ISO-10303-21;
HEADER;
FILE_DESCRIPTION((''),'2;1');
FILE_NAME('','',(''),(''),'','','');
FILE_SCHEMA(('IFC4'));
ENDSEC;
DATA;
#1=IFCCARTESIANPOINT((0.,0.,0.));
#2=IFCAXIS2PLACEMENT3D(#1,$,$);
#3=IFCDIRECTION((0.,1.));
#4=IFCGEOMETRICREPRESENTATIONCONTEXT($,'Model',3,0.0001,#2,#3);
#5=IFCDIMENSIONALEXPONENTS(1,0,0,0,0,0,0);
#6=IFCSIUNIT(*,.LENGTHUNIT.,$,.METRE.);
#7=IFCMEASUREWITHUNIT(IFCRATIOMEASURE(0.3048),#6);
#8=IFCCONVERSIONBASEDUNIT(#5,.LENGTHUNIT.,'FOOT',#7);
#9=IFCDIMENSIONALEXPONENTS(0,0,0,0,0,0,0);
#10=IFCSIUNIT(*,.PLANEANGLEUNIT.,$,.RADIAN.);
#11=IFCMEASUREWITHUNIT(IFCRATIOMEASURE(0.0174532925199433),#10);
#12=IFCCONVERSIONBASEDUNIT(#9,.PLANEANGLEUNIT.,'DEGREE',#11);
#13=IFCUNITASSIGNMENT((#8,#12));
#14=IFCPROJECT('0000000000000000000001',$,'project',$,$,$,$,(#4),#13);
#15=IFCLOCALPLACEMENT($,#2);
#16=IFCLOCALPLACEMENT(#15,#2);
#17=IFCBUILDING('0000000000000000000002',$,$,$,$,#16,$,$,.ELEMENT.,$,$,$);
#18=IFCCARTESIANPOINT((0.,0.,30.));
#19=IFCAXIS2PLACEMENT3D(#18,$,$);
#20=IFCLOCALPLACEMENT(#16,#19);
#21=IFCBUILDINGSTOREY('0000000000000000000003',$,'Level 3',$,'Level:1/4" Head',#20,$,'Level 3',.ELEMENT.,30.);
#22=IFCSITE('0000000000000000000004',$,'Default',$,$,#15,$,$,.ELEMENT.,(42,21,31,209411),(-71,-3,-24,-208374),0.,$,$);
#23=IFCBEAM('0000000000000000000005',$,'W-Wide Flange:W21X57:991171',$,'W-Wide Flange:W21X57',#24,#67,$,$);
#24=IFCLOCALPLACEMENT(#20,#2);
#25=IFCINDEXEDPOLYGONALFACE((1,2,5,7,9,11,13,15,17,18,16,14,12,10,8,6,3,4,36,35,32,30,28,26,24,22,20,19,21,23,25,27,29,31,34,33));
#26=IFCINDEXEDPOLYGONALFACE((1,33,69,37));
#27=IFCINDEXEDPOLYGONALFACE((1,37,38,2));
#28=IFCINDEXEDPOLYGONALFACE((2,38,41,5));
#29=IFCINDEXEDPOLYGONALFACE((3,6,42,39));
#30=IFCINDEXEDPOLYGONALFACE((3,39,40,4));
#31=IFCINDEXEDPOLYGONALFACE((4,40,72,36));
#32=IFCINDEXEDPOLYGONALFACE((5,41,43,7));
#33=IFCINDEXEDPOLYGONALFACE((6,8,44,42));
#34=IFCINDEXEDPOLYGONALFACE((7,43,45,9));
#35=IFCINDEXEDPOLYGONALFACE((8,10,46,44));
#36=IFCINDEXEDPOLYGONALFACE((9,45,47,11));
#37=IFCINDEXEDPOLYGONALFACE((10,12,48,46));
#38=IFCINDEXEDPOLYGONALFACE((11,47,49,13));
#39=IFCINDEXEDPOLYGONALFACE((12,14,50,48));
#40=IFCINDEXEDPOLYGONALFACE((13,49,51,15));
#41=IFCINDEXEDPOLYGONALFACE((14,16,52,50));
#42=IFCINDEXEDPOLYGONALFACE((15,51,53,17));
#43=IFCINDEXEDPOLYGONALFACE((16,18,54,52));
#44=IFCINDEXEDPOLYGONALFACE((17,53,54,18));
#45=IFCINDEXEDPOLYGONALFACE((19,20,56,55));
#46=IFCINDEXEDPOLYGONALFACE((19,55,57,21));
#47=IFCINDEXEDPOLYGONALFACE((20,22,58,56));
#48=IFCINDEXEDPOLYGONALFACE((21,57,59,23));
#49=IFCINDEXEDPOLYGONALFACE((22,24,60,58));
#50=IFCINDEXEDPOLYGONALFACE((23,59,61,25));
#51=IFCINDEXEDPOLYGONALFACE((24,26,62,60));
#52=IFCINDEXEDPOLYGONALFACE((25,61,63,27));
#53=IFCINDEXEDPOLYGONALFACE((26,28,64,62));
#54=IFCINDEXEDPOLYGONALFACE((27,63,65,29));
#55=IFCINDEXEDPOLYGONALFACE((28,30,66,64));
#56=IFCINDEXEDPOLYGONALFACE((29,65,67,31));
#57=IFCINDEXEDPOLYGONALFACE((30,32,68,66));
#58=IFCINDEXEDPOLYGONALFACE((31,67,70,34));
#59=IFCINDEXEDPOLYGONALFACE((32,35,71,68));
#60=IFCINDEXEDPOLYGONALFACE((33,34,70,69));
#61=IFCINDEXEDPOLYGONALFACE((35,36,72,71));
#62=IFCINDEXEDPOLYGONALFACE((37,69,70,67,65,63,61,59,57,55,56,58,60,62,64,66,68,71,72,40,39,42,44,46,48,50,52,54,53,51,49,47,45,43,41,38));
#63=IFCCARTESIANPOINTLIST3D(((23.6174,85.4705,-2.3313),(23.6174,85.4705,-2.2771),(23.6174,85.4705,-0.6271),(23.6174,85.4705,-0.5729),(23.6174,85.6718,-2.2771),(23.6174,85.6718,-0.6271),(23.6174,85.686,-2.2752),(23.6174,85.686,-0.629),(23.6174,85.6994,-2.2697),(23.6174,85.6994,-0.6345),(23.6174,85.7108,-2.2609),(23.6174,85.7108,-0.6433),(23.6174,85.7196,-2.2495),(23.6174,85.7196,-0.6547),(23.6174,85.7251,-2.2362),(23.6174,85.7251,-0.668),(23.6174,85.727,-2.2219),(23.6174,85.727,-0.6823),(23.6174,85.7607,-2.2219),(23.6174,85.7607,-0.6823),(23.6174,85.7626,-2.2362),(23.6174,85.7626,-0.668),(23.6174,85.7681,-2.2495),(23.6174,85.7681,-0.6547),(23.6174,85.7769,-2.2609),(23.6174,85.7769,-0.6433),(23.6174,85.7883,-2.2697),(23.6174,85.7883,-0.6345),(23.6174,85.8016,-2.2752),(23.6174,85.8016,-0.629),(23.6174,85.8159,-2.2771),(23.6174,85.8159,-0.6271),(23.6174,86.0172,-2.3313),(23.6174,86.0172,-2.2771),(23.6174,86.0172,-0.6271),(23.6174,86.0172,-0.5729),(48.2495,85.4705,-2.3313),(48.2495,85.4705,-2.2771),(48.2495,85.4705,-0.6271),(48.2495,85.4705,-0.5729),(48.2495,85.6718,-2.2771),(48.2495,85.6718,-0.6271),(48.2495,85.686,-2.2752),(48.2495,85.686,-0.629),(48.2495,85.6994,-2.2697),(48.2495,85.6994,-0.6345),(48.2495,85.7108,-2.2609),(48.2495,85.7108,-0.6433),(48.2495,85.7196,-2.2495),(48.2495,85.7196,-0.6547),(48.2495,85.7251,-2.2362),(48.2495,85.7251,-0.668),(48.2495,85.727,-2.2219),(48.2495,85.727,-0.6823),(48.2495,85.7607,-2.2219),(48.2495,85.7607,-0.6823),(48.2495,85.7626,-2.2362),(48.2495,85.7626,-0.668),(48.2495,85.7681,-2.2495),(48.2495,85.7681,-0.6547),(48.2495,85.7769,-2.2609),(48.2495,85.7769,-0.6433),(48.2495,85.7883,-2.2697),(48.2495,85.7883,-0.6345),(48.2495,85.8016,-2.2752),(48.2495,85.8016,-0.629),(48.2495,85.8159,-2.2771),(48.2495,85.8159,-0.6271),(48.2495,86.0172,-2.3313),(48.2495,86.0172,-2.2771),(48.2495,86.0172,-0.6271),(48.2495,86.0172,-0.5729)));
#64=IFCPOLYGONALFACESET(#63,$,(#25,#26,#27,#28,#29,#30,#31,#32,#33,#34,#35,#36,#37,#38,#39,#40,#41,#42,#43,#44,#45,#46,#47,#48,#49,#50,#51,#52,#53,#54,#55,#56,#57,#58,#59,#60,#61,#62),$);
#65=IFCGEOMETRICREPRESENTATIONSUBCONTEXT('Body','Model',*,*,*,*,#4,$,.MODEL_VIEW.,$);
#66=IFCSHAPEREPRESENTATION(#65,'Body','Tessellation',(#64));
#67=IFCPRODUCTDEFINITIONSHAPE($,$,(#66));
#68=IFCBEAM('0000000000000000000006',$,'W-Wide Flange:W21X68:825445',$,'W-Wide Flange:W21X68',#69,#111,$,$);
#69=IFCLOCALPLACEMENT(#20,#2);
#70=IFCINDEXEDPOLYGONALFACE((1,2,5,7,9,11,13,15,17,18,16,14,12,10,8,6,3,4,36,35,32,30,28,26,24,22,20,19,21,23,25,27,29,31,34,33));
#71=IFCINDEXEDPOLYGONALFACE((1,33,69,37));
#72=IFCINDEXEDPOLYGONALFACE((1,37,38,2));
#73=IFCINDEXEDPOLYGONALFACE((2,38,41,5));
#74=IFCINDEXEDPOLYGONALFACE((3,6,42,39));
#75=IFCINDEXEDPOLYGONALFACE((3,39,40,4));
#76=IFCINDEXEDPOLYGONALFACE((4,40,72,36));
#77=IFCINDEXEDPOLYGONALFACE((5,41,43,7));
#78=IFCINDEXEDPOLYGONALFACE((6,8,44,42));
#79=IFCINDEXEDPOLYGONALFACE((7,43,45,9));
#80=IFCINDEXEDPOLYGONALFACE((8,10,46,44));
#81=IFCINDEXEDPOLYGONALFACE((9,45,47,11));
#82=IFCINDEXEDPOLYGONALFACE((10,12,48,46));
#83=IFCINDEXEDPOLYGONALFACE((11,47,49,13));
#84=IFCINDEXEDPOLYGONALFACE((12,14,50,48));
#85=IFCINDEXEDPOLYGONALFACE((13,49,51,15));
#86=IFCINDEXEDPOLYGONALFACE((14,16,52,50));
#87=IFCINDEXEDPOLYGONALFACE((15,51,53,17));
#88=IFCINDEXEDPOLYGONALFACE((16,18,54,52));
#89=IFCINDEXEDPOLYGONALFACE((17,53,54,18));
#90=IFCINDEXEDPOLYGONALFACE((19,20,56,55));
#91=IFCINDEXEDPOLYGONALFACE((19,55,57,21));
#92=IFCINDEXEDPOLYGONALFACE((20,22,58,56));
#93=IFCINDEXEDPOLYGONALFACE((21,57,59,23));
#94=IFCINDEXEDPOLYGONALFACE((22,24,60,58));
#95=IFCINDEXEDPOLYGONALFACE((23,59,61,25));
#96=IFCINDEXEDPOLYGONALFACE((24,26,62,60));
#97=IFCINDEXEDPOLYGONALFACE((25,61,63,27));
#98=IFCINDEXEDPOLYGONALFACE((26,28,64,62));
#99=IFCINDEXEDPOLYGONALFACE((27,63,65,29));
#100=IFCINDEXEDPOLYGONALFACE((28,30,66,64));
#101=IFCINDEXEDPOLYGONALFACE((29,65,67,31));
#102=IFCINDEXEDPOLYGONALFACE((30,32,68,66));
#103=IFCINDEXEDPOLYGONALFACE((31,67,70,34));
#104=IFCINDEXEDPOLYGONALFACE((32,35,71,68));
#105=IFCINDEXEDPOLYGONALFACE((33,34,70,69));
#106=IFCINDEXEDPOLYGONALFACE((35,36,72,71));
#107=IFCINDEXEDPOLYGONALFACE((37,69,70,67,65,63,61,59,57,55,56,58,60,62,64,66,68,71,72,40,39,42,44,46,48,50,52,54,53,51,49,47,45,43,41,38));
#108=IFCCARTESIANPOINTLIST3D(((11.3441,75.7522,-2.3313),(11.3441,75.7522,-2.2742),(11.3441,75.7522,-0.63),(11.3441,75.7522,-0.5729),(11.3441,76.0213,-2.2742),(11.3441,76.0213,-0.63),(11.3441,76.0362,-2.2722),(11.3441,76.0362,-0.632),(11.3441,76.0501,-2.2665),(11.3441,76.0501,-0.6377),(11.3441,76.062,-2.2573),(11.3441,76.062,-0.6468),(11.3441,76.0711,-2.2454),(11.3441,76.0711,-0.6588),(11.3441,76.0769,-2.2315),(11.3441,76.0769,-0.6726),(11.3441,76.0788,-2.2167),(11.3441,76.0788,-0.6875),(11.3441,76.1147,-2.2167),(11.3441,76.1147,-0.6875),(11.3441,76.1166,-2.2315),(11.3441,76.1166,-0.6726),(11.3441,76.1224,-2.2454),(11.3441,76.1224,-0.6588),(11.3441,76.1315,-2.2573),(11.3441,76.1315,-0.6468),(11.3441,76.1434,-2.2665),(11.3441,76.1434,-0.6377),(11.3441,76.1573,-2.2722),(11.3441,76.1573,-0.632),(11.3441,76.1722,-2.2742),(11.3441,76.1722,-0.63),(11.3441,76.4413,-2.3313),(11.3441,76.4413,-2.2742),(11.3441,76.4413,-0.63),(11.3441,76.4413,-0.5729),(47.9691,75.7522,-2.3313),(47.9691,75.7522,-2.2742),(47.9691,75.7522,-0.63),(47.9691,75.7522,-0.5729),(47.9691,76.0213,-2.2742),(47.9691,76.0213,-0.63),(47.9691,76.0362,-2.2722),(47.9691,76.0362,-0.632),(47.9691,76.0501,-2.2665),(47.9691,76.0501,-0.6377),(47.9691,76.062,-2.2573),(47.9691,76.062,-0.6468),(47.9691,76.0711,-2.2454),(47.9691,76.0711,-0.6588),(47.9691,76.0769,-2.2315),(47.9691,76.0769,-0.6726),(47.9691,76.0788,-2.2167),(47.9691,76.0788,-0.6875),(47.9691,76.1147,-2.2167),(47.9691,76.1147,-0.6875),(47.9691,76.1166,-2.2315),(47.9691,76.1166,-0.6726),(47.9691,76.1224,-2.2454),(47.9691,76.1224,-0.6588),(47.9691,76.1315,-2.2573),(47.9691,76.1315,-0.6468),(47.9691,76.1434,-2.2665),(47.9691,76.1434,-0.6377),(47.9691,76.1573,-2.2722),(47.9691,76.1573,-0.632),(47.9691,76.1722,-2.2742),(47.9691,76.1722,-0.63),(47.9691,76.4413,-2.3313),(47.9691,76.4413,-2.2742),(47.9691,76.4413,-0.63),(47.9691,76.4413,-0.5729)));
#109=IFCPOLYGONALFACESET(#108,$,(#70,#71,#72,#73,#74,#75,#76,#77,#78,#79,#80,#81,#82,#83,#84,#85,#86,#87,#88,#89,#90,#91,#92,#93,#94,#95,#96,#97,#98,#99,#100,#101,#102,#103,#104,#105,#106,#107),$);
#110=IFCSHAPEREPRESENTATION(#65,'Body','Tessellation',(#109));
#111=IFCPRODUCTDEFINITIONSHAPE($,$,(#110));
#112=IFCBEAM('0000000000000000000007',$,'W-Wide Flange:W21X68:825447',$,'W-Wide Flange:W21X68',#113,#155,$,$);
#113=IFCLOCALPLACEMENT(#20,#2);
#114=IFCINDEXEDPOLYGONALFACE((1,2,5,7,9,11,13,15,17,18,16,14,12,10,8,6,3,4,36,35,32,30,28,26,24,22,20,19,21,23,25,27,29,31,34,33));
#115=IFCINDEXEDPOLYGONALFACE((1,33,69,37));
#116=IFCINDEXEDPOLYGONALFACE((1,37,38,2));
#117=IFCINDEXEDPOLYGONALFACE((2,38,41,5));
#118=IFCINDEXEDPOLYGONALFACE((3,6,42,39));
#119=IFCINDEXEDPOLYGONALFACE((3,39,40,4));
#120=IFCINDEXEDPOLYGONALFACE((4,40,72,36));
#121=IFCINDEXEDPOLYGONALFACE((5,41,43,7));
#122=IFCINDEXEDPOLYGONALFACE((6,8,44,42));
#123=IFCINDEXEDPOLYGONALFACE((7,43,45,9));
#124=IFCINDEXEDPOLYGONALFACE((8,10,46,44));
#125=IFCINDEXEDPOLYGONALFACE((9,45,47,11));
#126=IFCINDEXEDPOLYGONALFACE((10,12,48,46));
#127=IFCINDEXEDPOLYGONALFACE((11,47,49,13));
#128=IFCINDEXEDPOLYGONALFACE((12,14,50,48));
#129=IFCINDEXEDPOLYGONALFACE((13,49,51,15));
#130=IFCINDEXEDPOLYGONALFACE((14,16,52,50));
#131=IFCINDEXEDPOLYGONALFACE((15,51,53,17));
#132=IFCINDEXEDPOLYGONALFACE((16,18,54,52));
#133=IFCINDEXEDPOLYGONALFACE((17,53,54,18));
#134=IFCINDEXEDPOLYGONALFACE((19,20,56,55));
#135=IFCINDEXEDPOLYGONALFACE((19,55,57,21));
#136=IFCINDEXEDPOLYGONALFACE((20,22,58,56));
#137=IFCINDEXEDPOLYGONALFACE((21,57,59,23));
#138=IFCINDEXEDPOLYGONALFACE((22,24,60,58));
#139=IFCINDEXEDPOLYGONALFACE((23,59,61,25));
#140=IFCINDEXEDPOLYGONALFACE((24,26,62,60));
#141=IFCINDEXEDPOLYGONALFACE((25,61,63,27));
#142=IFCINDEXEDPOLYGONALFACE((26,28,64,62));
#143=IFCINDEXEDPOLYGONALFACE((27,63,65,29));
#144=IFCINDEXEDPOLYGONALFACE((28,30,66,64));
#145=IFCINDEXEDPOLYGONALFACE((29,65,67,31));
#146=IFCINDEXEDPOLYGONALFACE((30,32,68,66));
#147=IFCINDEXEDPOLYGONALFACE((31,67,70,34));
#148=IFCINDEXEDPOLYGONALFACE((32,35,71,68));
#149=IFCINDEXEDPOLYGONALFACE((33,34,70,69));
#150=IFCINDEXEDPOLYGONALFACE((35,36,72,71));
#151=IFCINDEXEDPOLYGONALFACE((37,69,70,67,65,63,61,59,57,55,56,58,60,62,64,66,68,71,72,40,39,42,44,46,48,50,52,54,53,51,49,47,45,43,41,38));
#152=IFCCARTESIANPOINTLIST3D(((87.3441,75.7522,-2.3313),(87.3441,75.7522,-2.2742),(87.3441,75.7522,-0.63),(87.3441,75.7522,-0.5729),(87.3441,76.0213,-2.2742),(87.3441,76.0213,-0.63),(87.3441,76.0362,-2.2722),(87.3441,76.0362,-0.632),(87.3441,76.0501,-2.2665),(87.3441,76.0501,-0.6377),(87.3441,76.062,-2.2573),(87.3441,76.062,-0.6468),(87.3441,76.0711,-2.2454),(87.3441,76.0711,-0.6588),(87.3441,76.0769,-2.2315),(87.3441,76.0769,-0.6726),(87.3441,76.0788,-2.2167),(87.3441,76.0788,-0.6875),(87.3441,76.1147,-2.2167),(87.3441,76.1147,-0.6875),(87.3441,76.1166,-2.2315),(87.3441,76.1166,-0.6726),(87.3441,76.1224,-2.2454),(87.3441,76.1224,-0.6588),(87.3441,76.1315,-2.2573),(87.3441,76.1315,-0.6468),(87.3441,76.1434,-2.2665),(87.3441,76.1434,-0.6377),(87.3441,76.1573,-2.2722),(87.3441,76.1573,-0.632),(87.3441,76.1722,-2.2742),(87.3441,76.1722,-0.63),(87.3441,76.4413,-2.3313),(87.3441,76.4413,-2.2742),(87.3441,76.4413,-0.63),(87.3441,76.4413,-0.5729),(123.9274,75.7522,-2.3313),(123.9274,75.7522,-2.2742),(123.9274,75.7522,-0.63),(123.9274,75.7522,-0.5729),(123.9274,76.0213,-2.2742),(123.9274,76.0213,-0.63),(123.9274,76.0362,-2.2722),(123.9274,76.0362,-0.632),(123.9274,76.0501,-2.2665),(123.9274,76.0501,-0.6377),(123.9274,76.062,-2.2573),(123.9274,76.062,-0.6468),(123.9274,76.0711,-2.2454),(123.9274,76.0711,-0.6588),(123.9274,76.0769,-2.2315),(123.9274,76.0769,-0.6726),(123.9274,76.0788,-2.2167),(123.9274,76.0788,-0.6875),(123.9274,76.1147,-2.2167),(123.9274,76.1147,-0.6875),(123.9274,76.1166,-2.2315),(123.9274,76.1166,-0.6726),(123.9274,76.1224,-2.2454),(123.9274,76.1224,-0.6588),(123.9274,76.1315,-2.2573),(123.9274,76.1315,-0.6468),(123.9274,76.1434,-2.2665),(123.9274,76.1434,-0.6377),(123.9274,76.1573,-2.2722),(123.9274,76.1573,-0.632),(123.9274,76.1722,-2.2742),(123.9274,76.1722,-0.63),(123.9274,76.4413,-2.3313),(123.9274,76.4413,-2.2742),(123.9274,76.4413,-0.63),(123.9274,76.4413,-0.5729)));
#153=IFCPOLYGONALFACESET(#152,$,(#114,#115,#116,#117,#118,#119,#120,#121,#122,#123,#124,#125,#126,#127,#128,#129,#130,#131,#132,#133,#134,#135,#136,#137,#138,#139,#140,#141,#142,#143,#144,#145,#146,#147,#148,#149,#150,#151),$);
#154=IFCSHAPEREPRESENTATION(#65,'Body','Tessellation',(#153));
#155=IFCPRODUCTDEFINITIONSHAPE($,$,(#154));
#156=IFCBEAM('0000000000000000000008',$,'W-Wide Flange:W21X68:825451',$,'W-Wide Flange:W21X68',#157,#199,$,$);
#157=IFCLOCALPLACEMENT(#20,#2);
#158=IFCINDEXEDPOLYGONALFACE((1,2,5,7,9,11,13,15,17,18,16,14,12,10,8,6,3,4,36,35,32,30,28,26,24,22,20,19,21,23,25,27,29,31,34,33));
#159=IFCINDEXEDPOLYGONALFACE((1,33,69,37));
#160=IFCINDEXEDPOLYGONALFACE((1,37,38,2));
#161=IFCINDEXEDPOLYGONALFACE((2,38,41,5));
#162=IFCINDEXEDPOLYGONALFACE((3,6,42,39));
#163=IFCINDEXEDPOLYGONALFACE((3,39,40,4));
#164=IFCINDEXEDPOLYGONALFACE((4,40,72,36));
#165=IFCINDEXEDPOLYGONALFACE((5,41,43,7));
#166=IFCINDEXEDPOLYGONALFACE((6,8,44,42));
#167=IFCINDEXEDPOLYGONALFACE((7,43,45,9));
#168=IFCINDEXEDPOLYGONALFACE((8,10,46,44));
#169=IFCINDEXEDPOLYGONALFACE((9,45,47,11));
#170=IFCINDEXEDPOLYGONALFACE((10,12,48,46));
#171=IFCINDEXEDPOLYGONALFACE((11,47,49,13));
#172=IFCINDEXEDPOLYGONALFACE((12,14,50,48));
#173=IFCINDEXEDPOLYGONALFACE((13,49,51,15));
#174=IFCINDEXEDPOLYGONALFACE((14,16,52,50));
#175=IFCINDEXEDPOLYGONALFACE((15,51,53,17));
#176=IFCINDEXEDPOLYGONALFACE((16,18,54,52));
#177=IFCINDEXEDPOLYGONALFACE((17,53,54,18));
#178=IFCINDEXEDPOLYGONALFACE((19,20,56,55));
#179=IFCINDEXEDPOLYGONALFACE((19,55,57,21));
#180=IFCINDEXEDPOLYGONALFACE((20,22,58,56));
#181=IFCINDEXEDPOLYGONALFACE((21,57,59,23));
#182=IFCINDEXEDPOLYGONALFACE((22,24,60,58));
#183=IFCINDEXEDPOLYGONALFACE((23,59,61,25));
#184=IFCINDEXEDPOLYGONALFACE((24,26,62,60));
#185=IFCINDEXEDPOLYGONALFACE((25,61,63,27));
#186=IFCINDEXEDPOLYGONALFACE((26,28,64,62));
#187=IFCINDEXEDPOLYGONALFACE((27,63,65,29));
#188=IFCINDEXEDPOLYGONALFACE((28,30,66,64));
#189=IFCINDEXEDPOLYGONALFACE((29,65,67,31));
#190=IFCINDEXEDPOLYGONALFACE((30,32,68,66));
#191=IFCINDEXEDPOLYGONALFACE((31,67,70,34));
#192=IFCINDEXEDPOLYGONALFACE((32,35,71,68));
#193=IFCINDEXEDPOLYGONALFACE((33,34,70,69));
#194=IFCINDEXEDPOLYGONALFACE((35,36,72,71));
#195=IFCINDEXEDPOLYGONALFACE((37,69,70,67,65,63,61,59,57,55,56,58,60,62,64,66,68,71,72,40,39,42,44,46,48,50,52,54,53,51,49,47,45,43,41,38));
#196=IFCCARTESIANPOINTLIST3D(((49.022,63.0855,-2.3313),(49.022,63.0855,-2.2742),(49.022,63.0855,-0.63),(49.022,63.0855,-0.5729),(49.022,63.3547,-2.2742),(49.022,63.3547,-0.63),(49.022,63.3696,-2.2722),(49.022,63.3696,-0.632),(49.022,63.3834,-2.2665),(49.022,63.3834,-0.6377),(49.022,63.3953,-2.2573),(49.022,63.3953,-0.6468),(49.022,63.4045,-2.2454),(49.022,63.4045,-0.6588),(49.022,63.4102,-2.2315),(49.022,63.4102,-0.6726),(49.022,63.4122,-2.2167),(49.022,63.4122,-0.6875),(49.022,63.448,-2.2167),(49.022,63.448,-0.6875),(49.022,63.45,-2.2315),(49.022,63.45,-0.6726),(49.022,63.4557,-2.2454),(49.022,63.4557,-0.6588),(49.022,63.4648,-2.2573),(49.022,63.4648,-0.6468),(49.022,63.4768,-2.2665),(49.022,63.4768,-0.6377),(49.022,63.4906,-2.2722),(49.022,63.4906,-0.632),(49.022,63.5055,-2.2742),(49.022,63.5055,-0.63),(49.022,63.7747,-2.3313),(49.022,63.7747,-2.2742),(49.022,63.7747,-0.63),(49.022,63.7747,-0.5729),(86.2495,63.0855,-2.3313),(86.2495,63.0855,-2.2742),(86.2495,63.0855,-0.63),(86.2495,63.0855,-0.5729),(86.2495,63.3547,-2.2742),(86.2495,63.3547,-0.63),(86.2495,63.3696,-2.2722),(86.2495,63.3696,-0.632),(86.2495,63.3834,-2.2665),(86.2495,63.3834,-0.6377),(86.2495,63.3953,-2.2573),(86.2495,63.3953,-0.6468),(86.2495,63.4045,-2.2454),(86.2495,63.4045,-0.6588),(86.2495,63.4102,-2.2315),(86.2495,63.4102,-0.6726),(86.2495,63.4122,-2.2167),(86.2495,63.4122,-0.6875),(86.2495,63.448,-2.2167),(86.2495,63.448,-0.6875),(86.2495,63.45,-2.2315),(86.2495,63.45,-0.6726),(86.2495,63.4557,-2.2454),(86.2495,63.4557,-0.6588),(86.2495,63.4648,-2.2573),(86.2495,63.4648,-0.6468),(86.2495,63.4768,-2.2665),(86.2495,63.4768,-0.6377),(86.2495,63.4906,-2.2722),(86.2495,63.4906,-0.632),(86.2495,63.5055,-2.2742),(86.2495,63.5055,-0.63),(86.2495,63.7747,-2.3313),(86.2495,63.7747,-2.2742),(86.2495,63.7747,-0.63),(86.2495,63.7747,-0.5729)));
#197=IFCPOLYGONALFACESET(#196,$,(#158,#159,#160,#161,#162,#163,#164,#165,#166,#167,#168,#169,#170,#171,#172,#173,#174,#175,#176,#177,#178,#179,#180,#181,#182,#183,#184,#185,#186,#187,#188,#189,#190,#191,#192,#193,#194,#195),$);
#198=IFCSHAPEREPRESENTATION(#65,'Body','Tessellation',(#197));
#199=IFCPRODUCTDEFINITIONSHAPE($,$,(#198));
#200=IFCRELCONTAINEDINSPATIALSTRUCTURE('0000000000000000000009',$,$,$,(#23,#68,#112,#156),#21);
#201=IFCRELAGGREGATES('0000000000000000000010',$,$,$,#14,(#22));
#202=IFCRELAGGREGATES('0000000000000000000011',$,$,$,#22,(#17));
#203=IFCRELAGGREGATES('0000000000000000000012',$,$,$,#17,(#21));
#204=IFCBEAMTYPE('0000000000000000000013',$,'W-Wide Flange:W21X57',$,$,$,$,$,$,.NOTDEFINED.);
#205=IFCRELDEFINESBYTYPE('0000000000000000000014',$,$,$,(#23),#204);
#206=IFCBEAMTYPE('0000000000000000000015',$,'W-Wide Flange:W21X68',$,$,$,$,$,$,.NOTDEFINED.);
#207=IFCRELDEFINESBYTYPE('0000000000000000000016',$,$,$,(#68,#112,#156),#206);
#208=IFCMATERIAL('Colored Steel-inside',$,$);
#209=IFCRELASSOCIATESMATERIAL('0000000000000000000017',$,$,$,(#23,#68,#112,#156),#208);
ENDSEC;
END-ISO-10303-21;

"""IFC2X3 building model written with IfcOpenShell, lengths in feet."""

from ifc_helpers import new_model, entity, si_unit, converted_unit, direction, frame, frame_2d, origin, place, context, subcontext, project, spatial, i_section, extrude, material, type_object, element, save


model = new_model("IFC2X3")

# Units and contexts
model_context = context("Model", 3, precision=0.0001, world=origin(), true_north=direction((0.0, 1.0)))
body_context = subcontext(model_context, "Body", "Model", "MODEL_VIEW")
ifc_project = project(units=[converted_unit("LENGTHUNIT", "FOOT", entity("IfcRatioMeasure", 0.3048), si_unit("LENGTHUNIT", "METRE"), dimensions=[1, 0, 0, 0, 0, 0, 0]), converted_unit("PLANEANGLEUNIT", "DEGREE", entity("IfcRatioMeasure", 0.0174532925199433), si_unit("PLANEANGLEUNIT", "RADIAN"), dimensions=[0, 0, 0, 0, 0, 0, 0])], contexts=[model_context])

# Site, building, storey
site_placement = place(None, origin())
site = spatial("IfcSite", under=ifc_project, at=site_placement, Name="Default", CompositionType="ELEMENT", RefLatitude=(42, 21, 31, 209411), RefLongitude=(-71, -3, -24, -208374), RefElevation=0.0)
building_placement = place(site_placement, origin())
building = spatial("IfcBuilding", under=site, at=building_placement, CompositionType="ELEMENT")
storey_placement = place(building_placement, frame((0.0, 0.0, 30.0)))
storey = spatial("IfcBuildingStorey", under=building, at=storey_placement, Name="Level 3", ObjectType="Level:1/4\" Head", LongName="Level 3", CompositionType="ELEMENT", Elevation=30.0)

# Beams
ifc_material_1 = material(Name="Colored Steel-inside")
beam_type_1 = type_object("IfcBeamType", Name="W-Wide Flange:W21X57", PredefinedType="NOTDEFINED")
beam_1_placement = place(storey_placement, frame((48.6358, 85.7438, 0.0), z_axis=(0.0, 0.0, 1.0), x_axis=(-1.0, 0.0, 0.0)))
element("IfcBeam", 1, at=beam_1_placement, inside=storey, type_object=beam_type_1, material=ifc_material_1, Name="W-Wide Flange:W21X57:991171", ObjectType="W-Wide Flange:W21X57", context=body_context, shape_type="SweptSolid", body=[
    extrude(i_section(OverallWidth=0.5467, OverallDepth=1.7583, WebThickness=0.0337, FlangeThickness=0.0542, FilletRadius=0.0552, at=frame_2d((0.0, 0.0), x_axis=(0.0, 1.0))), frame((0.3863, 0.0, -1.4521), z_axis=(1.0, 0.0, 0.0), x_axis=(0.0, 0.0, -1.0)), (0.0, 0.0, 1.0), 24.6321),
])
beam_type_2 = type_object("IfcBeamType", Name="W-Wide Flange:W21X68", PredefinedType="NOTDEFINED")
beam_2_placement = place(storey_placement, frame((48.6554, 76.0968, 0.0), z_axis=(0.0, 0.0, 1.0), x_axis=(-1.0, 0.0, 0.0)))
element("IfcBeam", 2, at=beam_2_placement, inside=storey, type_object=beam_type_2, material=ifc_material_1, Name="W-Wide Flange:W21X68:825445", ObjectType="W-Wide Flange:W21X68", context=body_context, shape_type="SweptSolid", body=[
    extrude(i_section(OverallWidth=0.6892, OverallDepth=1.7583, WebThickness=0.0358, FlangeThickness=0.0571, FilletRadius=0.0575, at=frame_2d((0.0, 0.0), x_axis=(0.0, 1.0))), frame((0.6862, 0.0, -1.4521), z_axis=(1.0, 0.0, 0.0), x_axis=(0.0, 0.0, -1.0)), (0.0, 0.0, 1.0), 36.625),
])
beam_3_placement = place(storey_placement, frame((86.6554, 76.0968, 0.0)))
element("IfcBeam", 3, at=beam_3_placement, inside=storey, type_object=beam_type_2, material=ifc_material_1, Name="W-Wide Flange:W21X68:825447", ObjectType="W-Wide Flange:W21X68", context=body_context, shape_type="SweptSolid", body=[
    extrude(i_section(OverallWidth=0.6892, OverallDepth=1.7583, WebThickness=0.0358, FlangeThickness=0.0571, FilletRadius=0.0575, at=frame_2d((0.0, 0.0), x_axis=(0.0, 1.0))), frame((0.6888, 0.0, -1.4521), z_axis=(1.0, 0.0, 0.0), x_axis=(0.0, 0.0, -1.0)), (0.0, 0.0, 1.0), 36.5833),
])
beam_4_placement = place(storey_placement, frame((48.6554, 63.4301, 0.0)))
element("IfcBeam", 4, at=beam_4_placement, inside=storey, type_object=beam_type_2, material=ifc_material_1, Name="W-Wide Flange:W21X68:825451", ObjectType="W-Wide Flange:W21X68", context=body_context, shape_type="SweptSolid", body=[
    extrude(i_section(OverallWidth=0.6892, OverallDepth=1.7583, WebThickness=0.0358, FlangeThickness=0.0571, FilletRadius=0.0575, at=frame_2d((0.0, 0.0), x_axis=(0.0, 1.0))), frame((0.3667, 0.0, -1.4521), z_axis=(1.0, 0.0, 0.0), x_axis=(0.0, 0.0, -1.0)), (0.0, 0.0, 1.0), 37.2275),
])

save(model, "model.ifc")
